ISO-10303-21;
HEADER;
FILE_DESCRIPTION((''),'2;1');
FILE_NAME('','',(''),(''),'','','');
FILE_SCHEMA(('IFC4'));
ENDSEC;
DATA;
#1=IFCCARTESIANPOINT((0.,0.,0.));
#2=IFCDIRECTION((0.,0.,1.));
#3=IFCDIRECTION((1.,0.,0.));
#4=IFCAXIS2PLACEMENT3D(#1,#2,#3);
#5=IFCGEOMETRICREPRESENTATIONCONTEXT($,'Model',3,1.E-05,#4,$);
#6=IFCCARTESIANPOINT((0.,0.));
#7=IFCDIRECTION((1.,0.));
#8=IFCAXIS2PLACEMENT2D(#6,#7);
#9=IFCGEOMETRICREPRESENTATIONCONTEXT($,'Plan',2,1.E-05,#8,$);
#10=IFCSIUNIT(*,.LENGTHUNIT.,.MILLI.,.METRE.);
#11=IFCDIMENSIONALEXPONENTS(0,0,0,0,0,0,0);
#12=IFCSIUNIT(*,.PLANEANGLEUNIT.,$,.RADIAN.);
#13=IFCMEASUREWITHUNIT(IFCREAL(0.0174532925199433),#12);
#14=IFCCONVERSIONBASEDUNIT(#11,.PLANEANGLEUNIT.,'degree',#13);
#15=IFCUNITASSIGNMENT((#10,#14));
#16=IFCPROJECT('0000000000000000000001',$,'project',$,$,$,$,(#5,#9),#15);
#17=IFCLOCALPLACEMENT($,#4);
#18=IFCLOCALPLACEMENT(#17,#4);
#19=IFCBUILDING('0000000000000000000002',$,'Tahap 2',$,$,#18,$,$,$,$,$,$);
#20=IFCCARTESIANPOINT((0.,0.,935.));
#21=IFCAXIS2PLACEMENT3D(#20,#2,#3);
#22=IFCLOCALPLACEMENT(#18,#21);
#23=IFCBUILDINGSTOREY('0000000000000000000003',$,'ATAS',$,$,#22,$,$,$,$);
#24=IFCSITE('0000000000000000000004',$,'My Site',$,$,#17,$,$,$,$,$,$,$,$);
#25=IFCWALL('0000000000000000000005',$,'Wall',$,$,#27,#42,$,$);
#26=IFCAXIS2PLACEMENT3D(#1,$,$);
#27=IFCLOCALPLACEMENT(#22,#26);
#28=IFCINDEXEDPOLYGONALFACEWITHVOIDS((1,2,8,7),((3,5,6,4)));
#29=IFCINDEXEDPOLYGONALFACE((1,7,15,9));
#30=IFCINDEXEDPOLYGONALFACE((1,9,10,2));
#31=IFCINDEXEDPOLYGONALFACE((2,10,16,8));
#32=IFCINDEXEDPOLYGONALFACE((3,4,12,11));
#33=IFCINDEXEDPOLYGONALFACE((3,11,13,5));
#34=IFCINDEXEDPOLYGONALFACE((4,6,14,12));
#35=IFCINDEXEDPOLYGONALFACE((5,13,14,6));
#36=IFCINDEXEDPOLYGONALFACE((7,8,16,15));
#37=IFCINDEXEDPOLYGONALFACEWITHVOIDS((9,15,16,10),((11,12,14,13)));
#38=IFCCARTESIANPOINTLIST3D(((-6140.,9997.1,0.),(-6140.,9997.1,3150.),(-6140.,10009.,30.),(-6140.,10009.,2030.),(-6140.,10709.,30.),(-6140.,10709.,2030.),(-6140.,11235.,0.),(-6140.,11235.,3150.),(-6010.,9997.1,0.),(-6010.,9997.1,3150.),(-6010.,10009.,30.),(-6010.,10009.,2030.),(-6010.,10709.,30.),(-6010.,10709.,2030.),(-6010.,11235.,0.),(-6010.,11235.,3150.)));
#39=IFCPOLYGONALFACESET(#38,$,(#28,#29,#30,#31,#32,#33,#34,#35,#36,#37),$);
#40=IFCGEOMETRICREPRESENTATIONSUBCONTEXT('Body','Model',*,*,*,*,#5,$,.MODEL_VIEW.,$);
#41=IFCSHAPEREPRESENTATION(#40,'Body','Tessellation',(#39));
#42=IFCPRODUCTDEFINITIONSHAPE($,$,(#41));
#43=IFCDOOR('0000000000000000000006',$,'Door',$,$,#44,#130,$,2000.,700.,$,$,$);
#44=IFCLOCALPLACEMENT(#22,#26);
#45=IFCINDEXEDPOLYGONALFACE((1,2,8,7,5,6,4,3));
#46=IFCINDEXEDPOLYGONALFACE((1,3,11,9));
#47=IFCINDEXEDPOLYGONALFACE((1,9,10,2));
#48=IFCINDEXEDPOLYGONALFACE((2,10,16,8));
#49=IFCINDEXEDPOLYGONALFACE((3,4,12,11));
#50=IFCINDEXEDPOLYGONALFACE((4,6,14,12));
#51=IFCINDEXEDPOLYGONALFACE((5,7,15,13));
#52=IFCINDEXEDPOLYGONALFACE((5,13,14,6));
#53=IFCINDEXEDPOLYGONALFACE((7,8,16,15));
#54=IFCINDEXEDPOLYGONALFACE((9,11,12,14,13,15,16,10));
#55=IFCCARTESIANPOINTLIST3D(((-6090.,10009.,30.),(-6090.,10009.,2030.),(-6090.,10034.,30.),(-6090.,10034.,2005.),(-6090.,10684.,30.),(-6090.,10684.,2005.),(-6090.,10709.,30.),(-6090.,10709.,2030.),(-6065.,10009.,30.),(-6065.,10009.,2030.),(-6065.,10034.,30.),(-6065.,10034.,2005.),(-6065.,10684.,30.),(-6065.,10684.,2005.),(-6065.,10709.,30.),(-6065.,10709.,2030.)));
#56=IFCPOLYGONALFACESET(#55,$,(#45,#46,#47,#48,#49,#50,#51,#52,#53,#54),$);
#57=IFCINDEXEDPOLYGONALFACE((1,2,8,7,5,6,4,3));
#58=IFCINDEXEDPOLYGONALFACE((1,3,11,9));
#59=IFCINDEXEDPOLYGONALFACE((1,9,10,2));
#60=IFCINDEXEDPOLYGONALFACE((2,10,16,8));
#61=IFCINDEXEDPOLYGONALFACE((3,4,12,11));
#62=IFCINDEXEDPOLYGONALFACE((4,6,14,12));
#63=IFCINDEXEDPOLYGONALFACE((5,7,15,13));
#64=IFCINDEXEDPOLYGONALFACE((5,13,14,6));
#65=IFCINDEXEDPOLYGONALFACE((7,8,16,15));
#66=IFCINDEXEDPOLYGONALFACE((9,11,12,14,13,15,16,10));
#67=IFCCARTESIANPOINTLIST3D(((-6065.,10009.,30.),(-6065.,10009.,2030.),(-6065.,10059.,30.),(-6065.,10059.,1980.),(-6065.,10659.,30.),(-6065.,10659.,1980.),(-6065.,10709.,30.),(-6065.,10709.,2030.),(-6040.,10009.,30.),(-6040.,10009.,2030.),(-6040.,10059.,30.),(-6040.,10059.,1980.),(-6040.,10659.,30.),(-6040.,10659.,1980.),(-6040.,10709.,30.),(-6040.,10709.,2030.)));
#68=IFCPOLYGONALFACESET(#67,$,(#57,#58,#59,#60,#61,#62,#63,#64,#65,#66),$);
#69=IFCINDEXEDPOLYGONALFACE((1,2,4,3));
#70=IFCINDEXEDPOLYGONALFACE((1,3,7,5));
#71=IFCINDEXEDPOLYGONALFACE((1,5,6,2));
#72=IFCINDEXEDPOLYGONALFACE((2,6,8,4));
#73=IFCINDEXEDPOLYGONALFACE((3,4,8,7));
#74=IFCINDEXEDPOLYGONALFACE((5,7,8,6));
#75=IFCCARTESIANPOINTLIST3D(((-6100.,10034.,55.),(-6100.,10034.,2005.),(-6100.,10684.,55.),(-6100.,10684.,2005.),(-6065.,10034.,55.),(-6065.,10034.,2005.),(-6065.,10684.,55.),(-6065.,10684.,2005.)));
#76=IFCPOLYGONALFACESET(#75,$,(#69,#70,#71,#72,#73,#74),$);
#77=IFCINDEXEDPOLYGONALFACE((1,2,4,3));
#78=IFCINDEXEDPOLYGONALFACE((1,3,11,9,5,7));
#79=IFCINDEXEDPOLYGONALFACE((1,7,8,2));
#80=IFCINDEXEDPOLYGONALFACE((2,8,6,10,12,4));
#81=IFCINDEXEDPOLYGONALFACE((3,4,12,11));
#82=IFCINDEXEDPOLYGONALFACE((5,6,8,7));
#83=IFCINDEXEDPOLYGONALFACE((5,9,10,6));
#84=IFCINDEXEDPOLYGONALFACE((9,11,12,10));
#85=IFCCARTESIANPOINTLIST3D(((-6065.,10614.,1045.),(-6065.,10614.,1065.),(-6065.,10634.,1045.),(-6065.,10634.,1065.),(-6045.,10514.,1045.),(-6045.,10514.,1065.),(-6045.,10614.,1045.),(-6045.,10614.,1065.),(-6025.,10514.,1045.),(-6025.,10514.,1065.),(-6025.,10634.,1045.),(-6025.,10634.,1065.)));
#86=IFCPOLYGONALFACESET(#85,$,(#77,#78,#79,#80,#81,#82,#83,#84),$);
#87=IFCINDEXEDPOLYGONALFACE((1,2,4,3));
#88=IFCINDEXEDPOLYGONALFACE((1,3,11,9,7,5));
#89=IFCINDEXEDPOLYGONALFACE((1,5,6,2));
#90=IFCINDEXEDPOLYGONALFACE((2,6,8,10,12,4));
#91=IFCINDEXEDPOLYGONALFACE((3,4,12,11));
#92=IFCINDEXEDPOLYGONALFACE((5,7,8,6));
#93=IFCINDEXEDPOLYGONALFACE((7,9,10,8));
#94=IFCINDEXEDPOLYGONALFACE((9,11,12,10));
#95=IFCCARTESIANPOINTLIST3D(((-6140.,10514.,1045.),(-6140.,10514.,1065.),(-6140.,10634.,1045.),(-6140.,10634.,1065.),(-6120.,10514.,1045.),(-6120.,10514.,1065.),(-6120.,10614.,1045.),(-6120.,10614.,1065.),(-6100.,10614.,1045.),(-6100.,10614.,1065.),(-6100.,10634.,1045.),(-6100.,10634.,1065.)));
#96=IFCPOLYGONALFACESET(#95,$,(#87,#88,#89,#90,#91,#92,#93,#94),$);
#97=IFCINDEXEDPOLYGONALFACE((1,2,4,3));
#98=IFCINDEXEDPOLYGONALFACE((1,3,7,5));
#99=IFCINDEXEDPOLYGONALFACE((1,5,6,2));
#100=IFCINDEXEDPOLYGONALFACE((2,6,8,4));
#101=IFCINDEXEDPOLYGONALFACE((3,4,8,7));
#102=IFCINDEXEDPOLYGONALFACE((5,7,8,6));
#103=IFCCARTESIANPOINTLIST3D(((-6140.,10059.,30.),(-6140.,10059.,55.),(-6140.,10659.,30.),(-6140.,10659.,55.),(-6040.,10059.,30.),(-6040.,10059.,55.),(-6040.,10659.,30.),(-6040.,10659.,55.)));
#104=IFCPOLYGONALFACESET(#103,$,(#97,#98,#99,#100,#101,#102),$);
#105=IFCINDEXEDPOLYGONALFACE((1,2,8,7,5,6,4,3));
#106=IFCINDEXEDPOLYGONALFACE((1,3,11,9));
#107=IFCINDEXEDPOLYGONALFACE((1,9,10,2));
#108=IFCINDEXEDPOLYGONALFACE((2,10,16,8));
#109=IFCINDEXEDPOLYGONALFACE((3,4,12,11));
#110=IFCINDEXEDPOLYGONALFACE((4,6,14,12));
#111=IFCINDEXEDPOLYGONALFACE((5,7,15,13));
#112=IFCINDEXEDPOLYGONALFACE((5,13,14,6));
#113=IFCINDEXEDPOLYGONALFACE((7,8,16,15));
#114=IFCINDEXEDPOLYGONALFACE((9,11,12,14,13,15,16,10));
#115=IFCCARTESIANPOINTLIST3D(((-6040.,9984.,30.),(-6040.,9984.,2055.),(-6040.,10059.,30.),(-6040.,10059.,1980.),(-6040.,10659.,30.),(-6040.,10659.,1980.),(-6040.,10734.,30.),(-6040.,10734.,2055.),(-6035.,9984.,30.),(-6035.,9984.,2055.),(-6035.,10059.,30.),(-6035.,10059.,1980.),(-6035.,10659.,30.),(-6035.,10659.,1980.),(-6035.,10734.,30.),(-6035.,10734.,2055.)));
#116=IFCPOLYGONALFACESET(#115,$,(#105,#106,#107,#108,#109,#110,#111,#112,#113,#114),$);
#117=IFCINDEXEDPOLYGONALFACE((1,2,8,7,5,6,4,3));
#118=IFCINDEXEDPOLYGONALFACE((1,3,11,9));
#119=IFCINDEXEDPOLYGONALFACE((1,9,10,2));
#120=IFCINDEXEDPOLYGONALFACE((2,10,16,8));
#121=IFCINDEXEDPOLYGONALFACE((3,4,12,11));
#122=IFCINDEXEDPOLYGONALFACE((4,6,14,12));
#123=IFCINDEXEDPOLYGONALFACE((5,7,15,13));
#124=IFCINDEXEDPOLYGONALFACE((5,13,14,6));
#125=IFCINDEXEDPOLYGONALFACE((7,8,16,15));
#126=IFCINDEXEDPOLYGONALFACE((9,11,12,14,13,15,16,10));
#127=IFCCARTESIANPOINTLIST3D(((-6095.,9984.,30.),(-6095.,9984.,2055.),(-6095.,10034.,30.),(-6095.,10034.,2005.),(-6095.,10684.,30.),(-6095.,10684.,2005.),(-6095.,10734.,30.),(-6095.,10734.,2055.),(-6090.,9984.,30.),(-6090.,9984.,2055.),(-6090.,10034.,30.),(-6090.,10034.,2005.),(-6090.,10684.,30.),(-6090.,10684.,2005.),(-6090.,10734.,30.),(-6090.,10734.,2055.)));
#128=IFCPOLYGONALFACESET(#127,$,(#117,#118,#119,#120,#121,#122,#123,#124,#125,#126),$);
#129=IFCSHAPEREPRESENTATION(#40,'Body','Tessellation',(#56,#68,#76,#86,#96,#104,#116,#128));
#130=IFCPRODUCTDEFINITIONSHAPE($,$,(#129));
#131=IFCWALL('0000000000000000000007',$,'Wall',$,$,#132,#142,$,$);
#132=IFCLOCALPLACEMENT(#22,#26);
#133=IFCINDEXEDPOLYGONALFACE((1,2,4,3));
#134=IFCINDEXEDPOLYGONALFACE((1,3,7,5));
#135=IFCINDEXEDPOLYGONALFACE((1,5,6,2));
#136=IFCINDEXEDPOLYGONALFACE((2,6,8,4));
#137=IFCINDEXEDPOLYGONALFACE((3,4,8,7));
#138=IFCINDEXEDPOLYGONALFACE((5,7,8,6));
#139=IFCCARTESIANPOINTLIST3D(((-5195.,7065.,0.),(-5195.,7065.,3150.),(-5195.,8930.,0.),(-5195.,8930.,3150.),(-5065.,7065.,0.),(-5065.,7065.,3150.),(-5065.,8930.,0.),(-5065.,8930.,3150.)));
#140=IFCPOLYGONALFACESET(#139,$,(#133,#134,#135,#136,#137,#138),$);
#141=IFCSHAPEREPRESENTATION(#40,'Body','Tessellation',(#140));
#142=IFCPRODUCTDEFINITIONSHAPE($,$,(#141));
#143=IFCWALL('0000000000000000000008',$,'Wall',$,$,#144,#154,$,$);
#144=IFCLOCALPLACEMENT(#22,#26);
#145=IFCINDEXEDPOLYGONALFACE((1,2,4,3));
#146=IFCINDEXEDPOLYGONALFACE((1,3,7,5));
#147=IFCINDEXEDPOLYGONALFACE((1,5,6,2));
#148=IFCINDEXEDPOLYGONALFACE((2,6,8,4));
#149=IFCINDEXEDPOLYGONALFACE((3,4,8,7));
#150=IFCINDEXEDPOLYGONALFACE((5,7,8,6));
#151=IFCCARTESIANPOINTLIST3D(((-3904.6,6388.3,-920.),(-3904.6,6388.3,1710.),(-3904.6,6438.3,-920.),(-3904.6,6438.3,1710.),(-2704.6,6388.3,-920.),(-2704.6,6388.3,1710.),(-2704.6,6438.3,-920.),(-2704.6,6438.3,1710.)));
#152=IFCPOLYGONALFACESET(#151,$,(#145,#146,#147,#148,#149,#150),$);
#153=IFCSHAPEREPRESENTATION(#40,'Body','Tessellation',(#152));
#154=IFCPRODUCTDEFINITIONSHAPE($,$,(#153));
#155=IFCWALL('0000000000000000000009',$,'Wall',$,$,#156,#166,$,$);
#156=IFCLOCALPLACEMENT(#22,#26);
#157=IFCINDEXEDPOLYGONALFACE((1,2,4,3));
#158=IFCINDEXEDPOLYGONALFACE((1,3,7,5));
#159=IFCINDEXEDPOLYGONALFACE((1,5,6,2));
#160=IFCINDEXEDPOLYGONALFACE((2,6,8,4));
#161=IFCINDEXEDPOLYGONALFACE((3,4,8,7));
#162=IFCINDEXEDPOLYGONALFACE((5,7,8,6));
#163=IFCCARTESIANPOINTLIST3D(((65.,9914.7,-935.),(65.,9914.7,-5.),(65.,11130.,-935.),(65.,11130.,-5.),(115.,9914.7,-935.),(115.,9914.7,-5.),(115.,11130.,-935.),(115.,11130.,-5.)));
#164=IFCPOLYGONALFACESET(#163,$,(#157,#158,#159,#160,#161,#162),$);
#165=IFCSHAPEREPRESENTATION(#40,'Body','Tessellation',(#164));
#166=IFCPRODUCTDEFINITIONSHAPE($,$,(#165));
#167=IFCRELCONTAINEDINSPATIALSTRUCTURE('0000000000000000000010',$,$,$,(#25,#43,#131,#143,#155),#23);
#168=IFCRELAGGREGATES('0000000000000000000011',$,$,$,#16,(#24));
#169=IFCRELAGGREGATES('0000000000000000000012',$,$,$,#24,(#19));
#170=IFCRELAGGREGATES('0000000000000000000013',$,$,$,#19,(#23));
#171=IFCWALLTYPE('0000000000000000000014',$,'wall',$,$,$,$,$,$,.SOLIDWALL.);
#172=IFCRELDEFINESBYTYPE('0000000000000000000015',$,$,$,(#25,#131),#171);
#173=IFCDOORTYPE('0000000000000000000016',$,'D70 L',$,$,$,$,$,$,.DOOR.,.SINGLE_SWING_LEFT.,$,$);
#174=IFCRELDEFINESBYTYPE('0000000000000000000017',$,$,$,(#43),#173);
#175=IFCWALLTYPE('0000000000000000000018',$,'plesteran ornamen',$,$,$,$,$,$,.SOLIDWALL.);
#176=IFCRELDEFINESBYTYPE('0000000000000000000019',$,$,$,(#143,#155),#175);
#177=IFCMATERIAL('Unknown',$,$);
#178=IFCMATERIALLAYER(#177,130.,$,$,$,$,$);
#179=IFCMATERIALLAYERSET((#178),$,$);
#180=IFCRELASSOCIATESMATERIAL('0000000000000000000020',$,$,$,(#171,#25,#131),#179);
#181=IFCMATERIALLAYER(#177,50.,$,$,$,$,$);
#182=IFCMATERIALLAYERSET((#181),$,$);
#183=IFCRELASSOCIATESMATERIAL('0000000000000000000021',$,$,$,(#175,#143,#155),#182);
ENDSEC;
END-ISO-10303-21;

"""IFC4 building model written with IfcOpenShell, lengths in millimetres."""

from ifc_helpers import new_model, entity, si_unit, converted_unit, frame, origin_with_axes, origin_2d_with_axis, place, context, subcontext, project, spatial, line, indexed_curve, outline, extrude, shape, source, transform, mapped, material, layer, layer_set, layer_usage, type_object, type_shapes, element, fill, save


model = new_model("IFC4")

# Units and contexts
model_context = context("Model", 3, precision=1e-05, world=origin_with_axes())
plan_context = context("Plan", 2, precision=1e-05, world=origin_2d_with_axis())
body_context_1 = subcontext(model_context, "Body", "Model", "MODEL_VIEW")
body_context_2 = subcontext(plan_context, "Body", "Plan", "PLAN_VIEW")
ifc_project = project(units=[si_unit("LENGTHUNIT", "METRE", prefix="MILLI"), converted_unit("PLANEANGLEUNIT", "degree", entity("IfcReal", 0.0174532925199433), si_unit("PLANEANGLEUNIT", "RADIAN"), dimensions=[0, 0, 0, 0, 0, 0, 0])], contexts=[model_context, plan_context])

# Site, building, storey
site_placement = place(None, origin_with_axes())
site = spatial("IfcSite", under=ifc_project, at=site_placement, Name="My Site")
building_placement = place(site_placement, origin_with_axes())
building = spatial("IfcBuilding", under=site, at=building_placement, Name="Tahap 2")
storey_placement = place(building_placement, frame((0.0, 0.0, 935.0), z_axis=(0.0, 0.0, 1.0), x_axis=(1.0, 0.0, 0.0)))
storey = spatial("IfcBuildingStorey", under=building, at=storey_placement, Name="ATAS")

# Shared definitions
ifc_material_1 = material(Name="Unknown")
ifc_layer_1 = layer(ifc_material_1, 130.0)
ifc_layer_set_1 = layer_set([ifc_layer_1])
wall_type_1 = type_object("IfcWallType", Name="wall", PredefinedType="SOLIDWALL", material=ifc_layer_set_1)

# Wall, opening, door
ifc_layer_usage_1 = layer_usage(ifc_layer_set_1, "AXIS2", "NEGATIVE", 0.0)
wall_1_placement = place(storey_placement, frame((-6010.0, 11235.0, 0.0), z_axis=(0.0, 0.0, 1.0), x_axis=(0.0, -1.0, 0.0)))
wall_1 = element("IfcWall", 1, at=wall_1_placement, inside=storey, type_object=wall_type_1, material=ifc_layer_usage_1, Name="Wall", context=body_context_1, shape_type="SweptSolid", body=[
    extrude(outline(indexed_curve([(0.0, -130.0), (0.0, 0.0), (1237.9, 0.0), (1237.9, -130.0)], segments=[line(1, 2, 3, 4, 1)])), origin_with_axes(), (0.0, 0.0, 1.0), 3150.0),
])
shared_shape_1 = source(origin_with_axes(), body_context_1, "Body", "SweptSolid", [
    extrude(outline(indexed_curve([(0.0, 0.0), (700.0, 0.0), (700.0, 2000.0), (0.0, 2000.0)], segments=[line(1, 2, 3, 4, 1)])), frame((0.0, -600.0, 0.0), z_axis=(0.0, -1.0, 0.0), x_axis=(1.0, 0.0, 0.0)), (0.0, 0.0, -1.0), 1200.0),
])
opening_1_placement = place(wall_1_placement, frame((1226.0, -30.0, 30.0), z_axis=(0.0, 0.0, 1.0), x_axis=(-1.0, 0.0, 0.0)))
opening_1 = element("IfcOpeningElement", 2, at=opening_1_placement, cuts=wall_1, PredefinedType="OPENING", context=body_context_1, shape_type="MappedRepresentation", body=[
    mapped(shared_shape_1, transform((0.0, 0.0, 0.0), x_axis=(1.0, 0.0, 0.0), y_axis=(0.0, 1.0, 0.0), z_axis=(0.0, 0.0, 1.0), scale=1.0)),
])
door_type_1 = type_object("IfcDoorType", Name="D70 L", OperationType="SINGLE_SWING_LEFT", PredefinedType="DOOR")
shared_shape_2 = source(origin_with_axes(), body_context_1, "Body", "SweptSolid", [
    extrude(outline(indexed_curve([(0.0, 0.0), (0.0, 2000.0), (700.0, 2000.0), (700.0, 0.0), (675.0, 0.0), (675.0, 1975.0), (25.0, 1975.0), (25.0, 0.0)], segments=[line(1, 2, 3, 4, 5, 6, 7, 8, 1)])), frame((0.0, 25.0, 0.0), z_axis=(0.0, -1.0, 0.0), x_axis=(1.0, 0.0, 0.0)), (0.0, 0.0, -1.0), 25.0),
    extrude(outline(indexed_curve([(0.0, 0.0), (0.0, 2000.0), (700.0, 2000.0), (700.0, 0.0), (650.0, 0.0), (650.0, 1950.0), (50.0, 1950.0), (50.0, 0.0)], segments=[line(1, 2, 3, 4, 5, 6, 7, 8, 1)])), frame((0.0, 0.0, 0.0), z_axis=(0.0, -1.0, 0.0), x_axis=(1.0, 0.0, 0.0)), (0.0, 0.0, -1.0), 25.0),
    extrude(outline(indexed_curve([(0.0, 0.0), (650.0, 0.0), (650.0, 35.0), (0.0, 35.0)], segments=[line(1, 2, 3, 4, 1)])), frame((25.0, 25.0, 25.0), z_axis=(0.0, 0.0, 1.0), x_axis=(1.0, 0.0, 0.0)), (0.0, 0.0, 1.0), 1950.0),
    extrude(outline(indexed_curve([(0.0, 0.0), (0.0, -40.0), (-120.0, -40.0), (-120.0, -20.0), (-20.0, -20.0), (-20.0, 0.0)], segments=[line(1, 2, 3, 4, 5, 6, 1)])), frame((625.0, 25.0, 1015.0), z_axis=(0.0, 0.0, 1.0), x_axis=(1.0, 0.0, 0.0)), (0.0, 0.0, 1.0), 20.0),
    extrude(outline(indexed_curve([(0.0, 0.0), (0.0, 40.0), (-120.0, 40.0), (-120.0, 20.0), (-20.0, 20.0), (-20.0, 0.0)], segments=[line(1, 2, 3, 4, 5, 6, 1)])), frame((625.0, 60.0, 1015.0), z_axis=(0.0, 0.0, 1.0), x_axis=(1.0, 0.0, 0.0)), (0.0, 0.0, 1.0), 20.0),
    extrude(outline(indexed_curve([(0.0, 0.0), (600.0, 0.0), (600.0, 100.0), (0.0, 100.0)], segments=[line(1, 2, 3, 4, 1)])), frame((50.0, 0.0, 0.0), z_axis=(0.0, 0.0, 1.0), x_axis=(1.0, 0.0, 0.0)), (0.0, 0.0, 1.0), 25.0),
    extrude(outline(indexed_curve([(0.0, 0.0), (0.0, 2025.0), (750.0, 2025.0), (750.0, 0.0), (675.0, 0.0), (675.0, 1950.0), (75.0, 1950.0), (75.0, 0.0)], segments=[line(1, 2, 3, 4, 5, 6, 7, 8, 1)])), frame((-25.0, -5.0, 0.0), z_axis=(0.0, -1.0, 0.0), x_axis=(1.0, 0.0, 0.0)), (0.0, 0.0, -1.0), 5.0),
    extrude(outline(indexed_curve([(0.0, 0.0), (0.0, 2025.0), (750.0, 2025.0), (750.0, 0.0), (700.0, 0.0), (700.0, 1975.0), (50.0, 1975.0), (50.0, 0.0)], segments=[line(1, 2, 3, 4, 5, 6, 7, 8, 1)])), frame((-25.0, 50.0, 0.0), z_axis=(0.0, -1.0, 0.0), x_axis=(1.0, 0.0, 0.0)), (0.0, 0.0, -1.0), 5.0),
])
shared_shape_3 = source(origin_with_axes(), body_context_2, "Body", "Curve2D", [
    entity("IfcIndexedPolyCurve", entity("IfcCartesianPointList2D", [[0.0, 0.0], [0.0, 50.0], [25.0, 50.0], [25.0, 25.0], [50.0, 25.0], [50.0, 0.0]]), [entity("IfcLineIndex", [1, 2, 3, 4, 5, 6, 1])]),
    entity("IfcIndexedPolyCurve", entity("IfcCartesianPointList2D", [[700.0, 0.0], [700.0, 50.0], [675.0, 50.0], [675.0, 25.0], [650.0, 25.0], [650.0, 0.0]]), [entity("IfcLineIndex", [1, 2, 3, 4, 5, 6, 1])]),
    entity("IfcTrimmedCurve", entity("IfcEllipse", entity("IfcAxis2Placement2D", entity("IfcCartesianPoint", [60.0, 50.0]), entity("IfcDirection", [1.0, 0.0])), 615.0, 650.0), [entity("IfcCartesianPoint", [675.0, 50.0])], [entity("IfcCartesianPoint", [60.0, 700.0])], True, "CARTESIAN"),
    entity("IfcIndexedPolyCurve", entity("IfcCartesianPointList2D", [[25.0, 50.0], [60.0, 50.0], [60.0, 700.0], [25.0, 700.0]]), [entity("IfcLineIndex", [1, 2, 3, 4, 1])]),
])
type_shapes(door_type_1, [shared_shape_2, shared_shape_3])
door_1_placement = place(opening_1_placement, frame((0.0, 0.0, 0.0), z_axis=(0.0, 0.0, 1.0), x_axis=(1.0, 0.0, 0.0)))
door_1 = element("IfcDoor", 3, at=door_1_placement, inside=storey, type_object=door_type_1, Name="Door", OverallHeight=2000.0, OverallWidth=700.0, shapes=[
    shape(body_context_1, "Body", "MappedRepresentation", [mapped(shared_shape_2, transform((0.0, 0.0, 0.0), x_axis=(1.0, 0.0, 0.0), y_axis=(0.0, 1.0, 0.0), z_axis=(0.0, 0.0, 1.0), scale=1.0))]),
    shape(body_context_2, "Body", "MappedRepresentation", [mapped(shared_shape_3, transform((0.0, 0.0, 0.0), x_axis=(1.0, 0.0, 0.0), y_axis=(0.0, 1.0, 0.0), z_axis=(0.0, 0.0, 1.0), scale=1.0))]),
])
fill(opening_1, door_1)

# Walls
ifc_layer_usage_2 = layer_usage(ifc_layer_set_1, "AXIS2", "POSITIVE", 0.0)
wall_2_placement = place(storey_placement, frame((-5195.0, 8930.0, 0.0), z_axis=(0.0, 0.0, 1.0), x_axis=(0.0, -1.0, 0.0)))
element("IfcWall", 4, at=wall_2_placement, inside=storey, type_object=wall_type_1, material=ifc_layer_usage_2, Name="Wall", context=body_context_1, shape_type="SweptSolid", body=[
    extrude(outline(indexed_curve([(0.0, 0.0), (0.0, 130.0), (1865.0, 130.0), (1865.0, 0.0)], segments=[line(1, 2, 3, 4, 1)])), origin_with_axes(), (0.0, 0.0, 1.0), 3150.0),
])
ifc_layer_2 = layer(ifc_material_1, 50.0)
ifc_layer_set_2 = layer_set([ifc_layer_2])
ifc_layer_usage_3 = layer_usage(ifc_layer_set_2, "AXIS2", "POSITIVE", 0.0)
wall_type_2 = type_object("IfcWallType", Name="plesteran ornamen", PredefinedType="SOLIDWALL", material=ifc_layer_set_2)
wall_3_placement = place(storey_placement, frame((-2704.6, 6438.3, -920.0), z_axis=(0.0, 0.0, 1.0), x_axis=(-1.0, 0.0, 0.0)))
element("IfcWall", 5, at=wall_3_placement, inside=storey, type_object=wall_type_2, material=ifc_layer_usage_3, Name="Wall", context=body_context_1, shape_type="SweptSolid", body=[
    extrude(outline(indexed_curve([(0.0, 0.0), (0.0, 50.0), (1200.0, 50.0), (1200.0, 0.0)], segments=[line(1, 2, 3, 4, 1)])), origin_with_axes(), (0.0, 0.0, 1.0), 2630.0),
])
ifc_layer_usage_4 = layer_usage(ifc_layer_set_2, "AXIS2", "NEGATIVE", 0.0)
wall_4_placement = place(storey_placement, frame((65.0, 9914.7, -935.0), z_axis=(0.0, 0.0, 1.0), x_axis=(0.000001, 1.0, 0.0)))
element("IfcWall", 6, at=wall_4_placement, inside=storey, type_object=wall_type_2, material=ifc_layer_usage_4, Name="Wall", context=body_context_1, shape_type="SweptSolid", body=[
    extrude(outline(indexed_curve([(0.0, -50.0), (0.0, 0.0), (1215.3, 0.0), (1215.3, -50.0)], segments=[line(1, 2, 3, 4, 1)])), origin_with_axes(), (0.0, 0.0, 1.0), 930.0),
])

save(model, "model.ifc")
